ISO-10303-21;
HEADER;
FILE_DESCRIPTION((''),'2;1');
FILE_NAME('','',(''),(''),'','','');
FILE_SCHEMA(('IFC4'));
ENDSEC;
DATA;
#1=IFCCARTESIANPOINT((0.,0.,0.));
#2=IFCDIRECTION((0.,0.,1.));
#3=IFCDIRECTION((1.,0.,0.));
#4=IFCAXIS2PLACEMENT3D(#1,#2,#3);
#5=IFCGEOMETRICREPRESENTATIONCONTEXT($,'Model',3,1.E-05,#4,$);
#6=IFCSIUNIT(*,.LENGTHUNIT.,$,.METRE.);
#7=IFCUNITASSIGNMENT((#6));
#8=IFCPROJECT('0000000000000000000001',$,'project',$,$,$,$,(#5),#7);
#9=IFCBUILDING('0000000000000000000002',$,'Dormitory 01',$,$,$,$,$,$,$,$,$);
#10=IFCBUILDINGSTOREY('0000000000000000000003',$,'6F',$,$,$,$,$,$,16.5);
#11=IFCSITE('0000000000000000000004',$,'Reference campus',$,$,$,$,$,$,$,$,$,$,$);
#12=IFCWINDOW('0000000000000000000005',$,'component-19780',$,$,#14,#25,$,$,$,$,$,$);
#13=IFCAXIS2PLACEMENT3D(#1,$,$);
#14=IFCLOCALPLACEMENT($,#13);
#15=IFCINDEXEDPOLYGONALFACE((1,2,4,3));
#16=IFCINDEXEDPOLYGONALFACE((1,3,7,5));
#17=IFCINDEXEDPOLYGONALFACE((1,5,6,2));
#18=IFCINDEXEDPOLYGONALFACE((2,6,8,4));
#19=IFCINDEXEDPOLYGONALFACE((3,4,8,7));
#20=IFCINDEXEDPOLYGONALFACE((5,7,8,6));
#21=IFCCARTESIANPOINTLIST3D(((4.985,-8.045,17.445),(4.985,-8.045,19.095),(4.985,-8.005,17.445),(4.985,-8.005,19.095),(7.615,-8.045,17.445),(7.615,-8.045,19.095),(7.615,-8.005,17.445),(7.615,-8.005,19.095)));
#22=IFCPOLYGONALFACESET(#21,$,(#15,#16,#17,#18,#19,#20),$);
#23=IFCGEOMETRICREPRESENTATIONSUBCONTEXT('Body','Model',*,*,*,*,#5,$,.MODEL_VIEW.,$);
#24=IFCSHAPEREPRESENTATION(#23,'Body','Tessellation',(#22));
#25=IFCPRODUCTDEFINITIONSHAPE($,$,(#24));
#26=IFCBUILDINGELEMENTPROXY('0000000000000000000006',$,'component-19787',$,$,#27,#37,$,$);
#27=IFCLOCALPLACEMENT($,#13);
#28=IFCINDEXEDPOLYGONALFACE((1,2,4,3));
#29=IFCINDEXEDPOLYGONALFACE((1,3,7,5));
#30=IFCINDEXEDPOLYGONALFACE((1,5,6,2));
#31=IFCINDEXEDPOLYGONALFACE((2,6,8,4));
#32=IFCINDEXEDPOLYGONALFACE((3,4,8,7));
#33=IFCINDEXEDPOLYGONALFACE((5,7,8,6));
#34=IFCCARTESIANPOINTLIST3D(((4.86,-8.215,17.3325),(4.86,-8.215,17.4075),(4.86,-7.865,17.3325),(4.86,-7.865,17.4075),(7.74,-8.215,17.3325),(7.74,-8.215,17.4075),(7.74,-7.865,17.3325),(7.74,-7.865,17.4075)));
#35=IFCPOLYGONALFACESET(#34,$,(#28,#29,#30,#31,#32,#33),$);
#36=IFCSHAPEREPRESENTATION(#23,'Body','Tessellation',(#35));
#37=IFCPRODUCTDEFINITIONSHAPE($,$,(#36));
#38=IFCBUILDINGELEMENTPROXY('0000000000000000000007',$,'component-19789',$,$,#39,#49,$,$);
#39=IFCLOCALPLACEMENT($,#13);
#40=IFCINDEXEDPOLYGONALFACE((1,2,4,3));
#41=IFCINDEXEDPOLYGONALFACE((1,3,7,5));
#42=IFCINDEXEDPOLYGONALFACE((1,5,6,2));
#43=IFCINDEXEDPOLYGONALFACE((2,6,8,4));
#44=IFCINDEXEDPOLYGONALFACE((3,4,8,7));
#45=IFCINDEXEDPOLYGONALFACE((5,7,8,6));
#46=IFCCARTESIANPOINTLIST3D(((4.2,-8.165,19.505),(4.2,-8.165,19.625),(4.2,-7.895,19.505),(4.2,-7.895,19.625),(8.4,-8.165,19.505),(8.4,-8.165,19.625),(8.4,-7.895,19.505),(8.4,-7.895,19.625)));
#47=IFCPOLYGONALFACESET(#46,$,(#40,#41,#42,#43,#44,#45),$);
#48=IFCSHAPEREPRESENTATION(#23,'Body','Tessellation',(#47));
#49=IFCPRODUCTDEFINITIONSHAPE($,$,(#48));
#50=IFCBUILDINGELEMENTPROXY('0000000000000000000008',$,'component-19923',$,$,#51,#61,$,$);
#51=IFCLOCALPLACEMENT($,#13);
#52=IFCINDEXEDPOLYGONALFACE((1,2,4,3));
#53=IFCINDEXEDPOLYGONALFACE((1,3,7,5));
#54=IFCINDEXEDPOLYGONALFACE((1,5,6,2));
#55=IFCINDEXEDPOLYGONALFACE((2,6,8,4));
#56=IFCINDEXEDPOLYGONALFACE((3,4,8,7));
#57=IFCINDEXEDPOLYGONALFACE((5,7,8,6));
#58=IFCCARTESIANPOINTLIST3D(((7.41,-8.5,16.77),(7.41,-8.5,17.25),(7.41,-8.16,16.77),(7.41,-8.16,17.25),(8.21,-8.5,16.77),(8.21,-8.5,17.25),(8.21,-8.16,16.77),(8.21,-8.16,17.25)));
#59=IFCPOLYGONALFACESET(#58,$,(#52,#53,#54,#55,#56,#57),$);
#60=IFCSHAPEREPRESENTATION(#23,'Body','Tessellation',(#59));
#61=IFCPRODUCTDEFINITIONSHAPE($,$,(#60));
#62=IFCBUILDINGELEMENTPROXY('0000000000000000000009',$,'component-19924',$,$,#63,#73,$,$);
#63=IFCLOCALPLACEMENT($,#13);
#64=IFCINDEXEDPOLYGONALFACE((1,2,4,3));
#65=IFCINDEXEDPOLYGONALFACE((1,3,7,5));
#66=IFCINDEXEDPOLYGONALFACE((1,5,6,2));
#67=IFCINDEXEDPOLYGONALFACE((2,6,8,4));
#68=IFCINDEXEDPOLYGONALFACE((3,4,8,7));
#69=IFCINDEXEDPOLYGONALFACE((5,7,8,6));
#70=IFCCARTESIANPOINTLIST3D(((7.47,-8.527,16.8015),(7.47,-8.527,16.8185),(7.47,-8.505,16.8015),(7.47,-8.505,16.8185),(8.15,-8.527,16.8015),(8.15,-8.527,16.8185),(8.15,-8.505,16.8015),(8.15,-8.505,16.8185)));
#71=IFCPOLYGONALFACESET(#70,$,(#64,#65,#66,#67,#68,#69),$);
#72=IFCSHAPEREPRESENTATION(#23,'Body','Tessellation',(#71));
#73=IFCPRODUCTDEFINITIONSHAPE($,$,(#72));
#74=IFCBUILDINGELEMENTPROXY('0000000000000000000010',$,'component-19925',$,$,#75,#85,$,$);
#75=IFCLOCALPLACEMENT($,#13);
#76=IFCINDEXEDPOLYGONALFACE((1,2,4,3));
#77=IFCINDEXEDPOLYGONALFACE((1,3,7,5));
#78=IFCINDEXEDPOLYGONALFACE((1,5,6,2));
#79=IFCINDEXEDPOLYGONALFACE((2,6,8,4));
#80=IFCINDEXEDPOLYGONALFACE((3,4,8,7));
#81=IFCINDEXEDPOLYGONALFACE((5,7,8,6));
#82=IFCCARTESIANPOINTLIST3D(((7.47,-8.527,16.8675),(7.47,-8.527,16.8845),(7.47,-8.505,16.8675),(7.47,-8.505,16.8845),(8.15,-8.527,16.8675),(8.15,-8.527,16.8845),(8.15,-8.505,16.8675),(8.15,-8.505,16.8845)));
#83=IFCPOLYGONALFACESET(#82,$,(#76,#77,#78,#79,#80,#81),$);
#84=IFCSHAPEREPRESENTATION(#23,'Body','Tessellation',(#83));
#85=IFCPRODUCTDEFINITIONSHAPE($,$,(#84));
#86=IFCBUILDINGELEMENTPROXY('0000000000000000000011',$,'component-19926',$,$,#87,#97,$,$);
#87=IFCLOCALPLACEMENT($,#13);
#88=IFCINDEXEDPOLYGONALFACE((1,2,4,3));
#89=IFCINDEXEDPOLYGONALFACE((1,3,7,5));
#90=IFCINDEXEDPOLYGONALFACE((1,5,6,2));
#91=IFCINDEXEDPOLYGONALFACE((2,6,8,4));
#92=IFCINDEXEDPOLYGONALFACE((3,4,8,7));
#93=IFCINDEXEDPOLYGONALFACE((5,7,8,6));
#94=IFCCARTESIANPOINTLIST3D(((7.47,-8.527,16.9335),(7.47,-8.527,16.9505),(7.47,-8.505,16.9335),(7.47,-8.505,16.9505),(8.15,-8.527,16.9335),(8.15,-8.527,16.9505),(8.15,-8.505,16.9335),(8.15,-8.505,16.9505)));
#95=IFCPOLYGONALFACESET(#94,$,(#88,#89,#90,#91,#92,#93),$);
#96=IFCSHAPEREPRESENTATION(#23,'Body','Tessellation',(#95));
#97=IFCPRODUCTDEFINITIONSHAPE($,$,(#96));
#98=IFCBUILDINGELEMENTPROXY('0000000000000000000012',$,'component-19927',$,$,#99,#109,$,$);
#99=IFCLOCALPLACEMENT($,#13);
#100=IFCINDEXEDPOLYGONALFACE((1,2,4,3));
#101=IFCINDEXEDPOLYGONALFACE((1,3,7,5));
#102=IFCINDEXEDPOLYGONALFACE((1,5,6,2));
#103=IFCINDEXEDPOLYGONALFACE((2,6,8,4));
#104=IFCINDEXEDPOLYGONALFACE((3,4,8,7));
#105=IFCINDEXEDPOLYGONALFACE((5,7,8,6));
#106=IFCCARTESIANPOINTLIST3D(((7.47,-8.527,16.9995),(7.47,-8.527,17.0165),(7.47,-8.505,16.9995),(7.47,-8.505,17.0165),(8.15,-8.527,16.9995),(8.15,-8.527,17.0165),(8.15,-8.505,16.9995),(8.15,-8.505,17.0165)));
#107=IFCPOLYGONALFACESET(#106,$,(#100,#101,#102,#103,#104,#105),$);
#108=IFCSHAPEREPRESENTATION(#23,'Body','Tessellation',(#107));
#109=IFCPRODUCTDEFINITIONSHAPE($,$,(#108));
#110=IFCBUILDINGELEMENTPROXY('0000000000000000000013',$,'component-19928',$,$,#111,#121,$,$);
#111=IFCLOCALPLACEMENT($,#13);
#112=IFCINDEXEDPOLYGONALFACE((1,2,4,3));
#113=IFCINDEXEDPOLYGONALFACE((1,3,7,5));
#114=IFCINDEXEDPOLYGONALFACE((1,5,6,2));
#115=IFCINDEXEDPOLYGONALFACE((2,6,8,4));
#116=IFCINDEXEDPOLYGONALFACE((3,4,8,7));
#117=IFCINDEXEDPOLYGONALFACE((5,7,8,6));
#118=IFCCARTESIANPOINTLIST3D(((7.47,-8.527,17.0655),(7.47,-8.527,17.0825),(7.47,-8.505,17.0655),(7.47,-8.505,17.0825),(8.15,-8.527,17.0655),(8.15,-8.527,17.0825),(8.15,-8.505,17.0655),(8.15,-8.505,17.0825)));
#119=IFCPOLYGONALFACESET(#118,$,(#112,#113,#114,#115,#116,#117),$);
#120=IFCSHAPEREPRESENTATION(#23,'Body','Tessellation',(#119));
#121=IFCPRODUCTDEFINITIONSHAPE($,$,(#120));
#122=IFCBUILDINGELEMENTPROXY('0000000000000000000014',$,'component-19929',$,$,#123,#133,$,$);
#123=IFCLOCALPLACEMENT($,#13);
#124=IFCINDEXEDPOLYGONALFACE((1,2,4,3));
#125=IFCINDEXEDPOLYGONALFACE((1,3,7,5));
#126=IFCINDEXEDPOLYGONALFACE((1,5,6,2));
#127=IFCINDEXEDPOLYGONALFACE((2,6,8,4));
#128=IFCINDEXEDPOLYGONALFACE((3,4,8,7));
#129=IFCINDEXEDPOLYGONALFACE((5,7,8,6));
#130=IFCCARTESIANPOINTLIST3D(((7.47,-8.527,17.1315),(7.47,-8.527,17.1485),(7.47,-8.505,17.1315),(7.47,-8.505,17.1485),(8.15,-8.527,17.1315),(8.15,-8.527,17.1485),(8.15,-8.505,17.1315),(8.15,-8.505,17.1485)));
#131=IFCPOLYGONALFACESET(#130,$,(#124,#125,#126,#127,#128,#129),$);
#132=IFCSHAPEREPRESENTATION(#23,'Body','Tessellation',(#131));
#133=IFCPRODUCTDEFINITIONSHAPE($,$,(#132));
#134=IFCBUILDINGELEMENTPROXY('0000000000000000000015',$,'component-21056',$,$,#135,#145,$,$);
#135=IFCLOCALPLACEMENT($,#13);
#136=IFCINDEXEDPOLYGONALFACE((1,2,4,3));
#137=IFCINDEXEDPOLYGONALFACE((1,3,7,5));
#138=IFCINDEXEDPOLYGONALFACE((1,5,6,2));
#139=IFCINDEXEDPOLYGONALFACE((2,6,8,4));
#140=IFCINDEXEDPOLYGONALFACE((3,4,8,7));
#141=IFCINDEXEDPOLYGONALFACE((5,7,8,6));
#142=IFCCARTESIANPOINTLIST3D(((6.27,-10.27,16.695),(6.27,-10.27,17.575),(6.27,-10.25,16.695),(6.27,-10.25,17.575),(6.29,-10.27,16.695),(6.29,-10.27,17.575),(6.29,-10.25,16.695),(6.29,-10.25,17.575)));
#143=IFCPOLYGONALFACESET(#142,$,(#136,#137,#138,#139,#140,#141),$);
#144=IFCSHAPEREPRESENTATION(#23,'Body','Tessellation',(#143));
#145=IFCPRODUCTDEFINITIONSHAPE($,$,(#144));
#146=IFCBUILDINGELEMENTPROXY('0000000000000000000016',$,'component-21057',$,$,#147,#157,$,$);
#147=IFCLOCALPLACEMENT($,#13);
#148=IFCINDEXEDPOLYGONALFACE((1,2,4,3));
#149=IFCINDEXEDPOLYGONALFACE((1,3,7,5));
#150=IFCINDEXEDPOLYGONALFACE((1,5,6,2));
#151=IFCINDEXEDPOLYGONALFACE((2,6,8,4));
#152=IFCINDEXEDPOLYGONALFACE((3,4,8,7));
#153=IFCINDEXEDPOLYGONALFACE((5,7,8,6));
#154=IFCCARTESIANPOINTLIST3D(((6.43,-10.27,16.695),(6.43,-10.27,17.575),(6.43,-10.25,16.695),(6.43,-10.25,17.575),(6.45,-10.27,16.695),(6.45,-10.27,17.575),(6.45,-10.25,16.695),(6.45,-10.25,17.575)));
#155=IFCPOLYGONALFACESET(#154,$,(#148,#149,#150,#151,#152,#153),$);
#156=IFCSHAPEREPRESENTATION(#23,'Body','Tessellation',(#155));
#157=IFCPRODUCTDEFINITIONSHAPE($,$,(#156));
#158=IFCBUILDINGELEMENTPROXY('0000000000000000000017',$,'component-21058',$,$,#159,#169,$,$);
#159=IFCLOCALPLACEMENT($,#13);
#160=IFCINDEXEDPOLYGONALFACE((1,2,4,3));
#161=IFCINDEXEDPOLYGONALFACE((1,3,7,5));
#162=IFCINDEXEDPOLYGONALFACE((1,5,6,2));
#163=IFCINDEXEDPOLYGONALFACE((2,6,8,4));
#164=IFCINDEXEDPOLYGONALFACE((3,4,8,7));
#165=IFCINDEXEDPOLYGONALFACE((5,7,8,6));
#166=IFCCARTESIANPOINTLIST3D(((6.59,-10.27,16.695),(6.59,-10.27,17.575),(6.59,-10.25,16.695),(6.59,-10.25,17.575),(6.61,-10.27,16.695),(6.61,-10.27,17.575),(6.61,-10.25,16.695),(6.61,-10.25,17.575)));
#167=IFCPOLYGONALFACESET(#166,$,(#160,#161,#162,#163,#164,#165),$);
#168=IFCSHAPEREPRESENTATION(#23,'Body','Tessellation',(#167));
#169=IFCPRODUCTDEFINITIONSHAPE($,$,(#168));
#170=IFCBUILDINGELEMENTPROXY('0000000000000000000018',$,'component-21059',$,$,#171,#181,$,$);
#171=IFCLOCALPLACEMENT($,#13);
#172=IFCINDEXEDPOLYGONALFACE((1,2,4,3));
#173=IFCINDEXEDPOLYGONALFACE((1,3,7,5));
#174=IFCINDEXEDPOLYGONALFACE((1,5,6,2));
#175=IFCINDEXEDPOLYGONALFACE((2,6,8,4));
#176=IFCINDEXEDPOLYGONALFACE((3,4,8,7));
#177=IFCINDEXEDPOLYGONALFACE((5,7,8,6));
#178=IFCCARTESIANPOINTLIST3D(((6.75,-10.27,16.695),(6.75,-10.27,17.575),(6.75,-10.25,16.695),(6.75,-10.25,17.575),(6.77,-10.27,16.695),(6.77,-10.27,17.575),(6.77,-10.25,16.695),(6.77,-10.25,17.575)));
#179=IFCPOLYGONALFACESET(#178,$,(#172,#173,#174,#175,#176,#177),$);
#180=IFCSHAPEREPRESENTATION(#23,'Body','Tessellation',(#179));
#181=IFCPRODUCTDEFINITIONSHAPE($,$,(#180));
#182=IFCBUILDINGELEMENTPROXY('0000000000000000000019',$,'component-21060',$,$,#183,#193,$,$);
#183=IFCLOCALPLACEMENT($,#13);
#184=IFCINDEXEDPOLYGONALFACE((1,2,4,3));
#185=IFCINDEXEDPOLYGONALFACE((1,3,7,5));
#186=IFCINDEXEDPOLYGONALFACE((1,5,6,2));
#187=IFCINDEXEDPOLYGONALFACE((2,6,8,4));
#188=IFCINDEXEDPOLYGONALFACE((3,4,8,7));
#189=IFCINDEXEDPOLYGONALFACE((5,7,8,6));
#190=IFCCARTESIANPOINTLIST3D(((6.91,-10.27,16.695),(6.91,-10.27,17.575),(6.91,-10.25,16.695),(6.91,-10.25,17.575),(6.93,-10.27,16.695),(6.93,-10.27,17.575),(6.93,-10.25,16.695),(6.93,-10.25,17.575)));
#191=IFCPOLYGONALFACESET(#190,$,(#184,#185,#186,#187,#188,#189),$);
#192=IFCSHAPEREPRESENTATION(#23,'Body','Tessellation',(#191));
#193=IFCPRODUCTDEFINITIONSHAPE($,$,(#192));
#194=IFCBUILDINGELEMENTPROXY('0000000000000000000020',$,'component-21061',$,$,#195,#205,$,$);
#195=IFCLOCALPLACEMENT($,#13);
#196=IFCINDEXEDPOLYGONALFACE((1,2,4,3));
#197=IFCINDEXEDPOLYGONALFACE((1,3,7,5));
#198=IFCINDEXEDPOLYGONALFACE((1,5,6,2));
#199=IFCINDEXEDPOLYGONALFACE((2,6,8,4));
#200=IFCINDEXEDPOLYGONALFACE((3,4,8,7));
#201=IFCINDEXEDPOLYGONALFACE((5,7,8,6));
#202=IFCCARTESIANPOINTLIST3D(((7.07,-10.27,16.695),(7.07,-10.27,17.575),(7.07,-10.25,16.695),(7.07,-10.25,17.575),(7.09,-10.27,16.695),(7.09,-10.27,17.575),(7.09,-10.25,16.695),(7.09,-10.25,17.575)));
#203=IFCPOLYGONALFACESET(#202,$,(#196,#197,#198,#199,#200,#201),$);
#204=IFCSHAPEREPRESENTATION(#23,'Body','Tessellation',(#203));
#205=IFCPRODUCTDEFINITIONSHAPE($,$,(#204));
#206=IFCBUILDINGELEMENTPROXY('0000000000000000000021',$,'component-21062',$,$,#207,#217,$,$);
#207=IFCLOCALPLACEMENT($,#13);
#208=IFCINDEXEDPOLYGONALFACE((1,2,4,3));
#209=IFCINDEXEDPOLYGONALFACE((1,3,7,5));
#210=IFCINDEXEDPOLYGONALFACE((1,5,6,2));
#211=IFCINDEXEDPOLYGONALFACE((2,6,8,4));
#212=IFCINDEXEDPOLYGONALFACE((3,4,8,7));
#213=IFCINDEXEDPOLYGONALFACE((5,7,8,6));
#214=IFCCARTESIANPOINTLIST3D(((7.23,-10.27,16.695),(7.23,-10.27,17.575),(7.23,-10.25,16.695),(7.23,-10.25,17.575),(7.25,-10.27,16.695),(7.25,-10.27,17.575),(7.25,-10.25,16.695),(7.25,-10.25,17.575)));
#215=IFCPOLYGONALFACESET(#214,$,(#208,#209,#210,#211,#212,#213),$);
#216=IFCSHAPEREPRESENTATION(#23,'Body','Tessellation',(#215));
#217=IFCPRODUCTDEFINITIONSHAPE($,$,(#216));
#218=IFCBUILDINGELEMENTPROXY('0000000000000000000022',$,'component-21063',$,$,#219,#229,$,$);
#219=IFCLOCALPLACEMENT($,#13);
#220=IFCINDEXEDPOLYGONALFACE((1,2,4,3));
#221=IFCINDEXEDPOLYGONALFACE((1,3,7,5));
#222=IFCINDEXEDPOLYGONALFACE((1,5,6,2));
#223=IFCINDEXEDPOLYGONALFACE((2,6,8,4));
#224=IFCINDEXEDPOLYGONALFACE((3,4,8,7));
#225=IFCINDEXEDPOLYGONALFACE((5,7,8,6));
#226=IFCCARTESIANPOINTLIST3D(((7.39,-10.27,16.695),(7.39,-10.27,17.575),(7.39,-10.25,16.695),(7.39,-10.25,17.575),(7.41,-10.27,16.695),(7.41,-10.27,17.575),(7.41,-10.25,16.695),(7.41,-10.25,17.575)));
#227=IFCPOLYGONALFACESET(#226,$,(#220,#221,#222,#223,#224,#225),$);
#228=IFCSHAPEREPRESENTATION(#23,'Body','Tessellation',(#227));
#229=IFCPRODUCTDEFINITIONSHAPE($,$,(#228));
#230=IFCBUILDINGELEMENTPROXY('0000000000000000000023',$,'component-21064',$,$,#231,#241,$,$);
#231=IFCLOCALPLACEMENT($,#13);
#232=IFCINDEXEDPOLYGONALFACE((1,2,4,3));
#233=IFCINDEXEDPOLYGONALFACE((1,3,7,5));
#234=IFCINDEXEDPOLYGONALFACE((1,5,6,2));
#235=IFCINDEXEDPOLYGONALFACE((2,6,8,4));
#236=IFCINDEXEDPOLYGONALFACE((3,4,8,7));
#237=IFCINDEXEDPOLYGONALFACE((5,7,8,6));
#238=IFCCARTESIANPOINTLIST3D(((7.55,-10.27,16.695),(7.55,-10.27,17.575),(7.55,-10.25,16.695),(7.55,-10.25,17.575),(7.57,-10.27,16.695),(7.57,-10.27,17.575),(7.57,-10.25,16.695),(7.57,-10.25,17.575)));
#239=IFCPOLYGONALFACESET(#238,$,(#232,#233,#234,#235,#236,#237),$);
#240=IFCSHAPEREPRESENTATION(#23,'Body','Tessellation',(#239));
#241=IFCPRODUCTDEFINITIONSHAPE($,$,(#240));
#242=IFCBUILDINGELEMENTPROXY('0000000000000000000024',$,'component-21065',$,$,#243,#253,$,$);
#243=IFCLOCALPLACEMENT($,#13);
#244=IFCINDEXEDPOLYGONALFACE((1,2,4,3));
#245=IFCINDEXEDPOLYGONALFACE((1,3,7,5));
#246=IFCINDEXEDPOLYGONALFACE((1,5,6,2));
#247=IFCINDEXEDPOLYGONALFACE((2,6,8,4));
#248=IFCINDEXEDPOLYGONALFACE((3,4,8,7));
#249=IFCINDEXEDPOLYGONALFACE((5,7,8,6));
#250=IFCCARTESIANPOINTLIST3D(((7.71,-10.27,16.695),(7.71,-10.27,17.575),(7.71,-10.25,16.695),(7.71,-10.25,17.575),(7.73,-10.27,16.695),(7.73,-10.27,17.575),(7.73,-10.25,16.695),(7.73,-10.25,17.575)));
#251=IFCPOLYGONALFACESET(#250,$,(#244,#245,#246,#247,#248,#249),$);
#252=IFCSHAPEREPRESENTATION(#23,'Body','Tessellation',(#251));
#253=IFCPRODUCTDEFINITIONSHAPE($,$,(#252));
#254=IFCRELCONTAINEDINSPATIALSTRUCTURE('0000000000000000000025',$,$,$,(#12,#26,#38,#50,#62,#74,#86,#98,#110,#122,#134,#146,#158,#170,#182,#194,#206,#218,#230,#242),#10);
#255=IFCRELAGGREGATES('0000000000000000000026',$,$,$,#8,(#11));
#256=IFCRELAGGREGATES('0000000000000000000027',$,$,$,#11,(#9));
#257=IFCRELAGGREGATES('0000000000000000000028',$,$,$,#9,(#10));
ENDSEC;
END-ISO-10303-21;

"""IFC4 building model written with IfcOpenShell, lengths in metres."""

from ifc_helpers import new_model, si_unit, frame, origin, origin_with_axes, origin_2d, place, context, subcontext, project, spatial, rectangle, extrude, element, save


model = new_model("IFC4")

# Units and contexts
model_context = context("Model", 3, precision=1e-05, world=origin_with_axes())
body_context = subcontext(model_context, "Body", "Model", "MODEL_VIEW")
ifc_project = project(units=[si_unit("LENGTHUNIT", "METRE")], contexts=[model_context])

# Site, building, storey
site = spatial("IfcSite", under=ifc_project, Name="Reference campus")
building = spatial("IfcBuilding", under=site, Name="Dormitory 01")
storey = spatial("IfcBuildingStorey", under=building, Name="6F", Elevation=16.5)

# Window
window_placement = place(None, frame((6.3, -8.025, 17.445), z_axis=(0.0, 0.0, 1.0), x_axis=(1.0, 0.0, 0.0)))
element("IfcWindow", 1, at=window_placement, inside=storey, Name="component-19780", context=body_context, shape_type="SweptSolid", body=[
    extrude(rectangle(XDim=2.63, YDim=0.04, at=origin_2d()), origin(), (0.0, 0.0, 1.0), 1.65),
])

# Building element proxies
proxy_1_placement = place(None, frame((6.3, -8.04, 17.3325), z_axis=(0.0, 0.0, 1.0), x_axis=(1.0, 0.0, 0.0)))
element("IfcBuildingElementProxy", 2, at=proxy_1_placement, inside=storey, Name="component-19787", context=body_context, shape_type="SweptSolid", body=[
    extrude(rectangle(XDim=2.88, YDim=0.35, at=origin_2d()), origin(), (0.0, 0.0, 1.0), 0.075),
])
proxy_2_placement = place(None, frame((6.3, -8.03, 19.505), z_axis=(0.0, 0.0, 1.0), x_axis=(1.0, 0.0, 0.0)))
element("IfcBuildingElementProxy", 3, at=proxy_2_placement, inside=storey, Name="component-19789", context=body_context, shape_type="SweptSolid", body=[
    extrude(rectangle(XDim=4.2, YDim=0.27, at=origin_2d()), origin(), (0.0, 0.0, 1.0), 0.12),
])
proxy_3_placement = place(None, frame((7.81, -8.33, 16.77), z_axis=(0.0, 0.0, 1.0), x_axis=(1.0, 0.0, 0.0)))
element("IfcBuildingElementProxy", 4, at=proxy_3_placement, inside=storey, Name="component-19923", context=body_context, shape_type="SweptSolid", body=[
    extrude(rectangle(XDim=0.8, YDim=0.34, at=origin_2d()), origin(), (0.0, 0.0, 1.0), 0.48),
])
for number, where, z_axis, x_axis, name in (
    (5, (7.81, -8.516, 16.8015), (0.0, 0.0, 1.0), (1.0, 0.0, 0.0), "component-19924"),
    (6, (7.81, -8.516, 16.8675), (0.0, 0.0, 1.0), (1.0, 0.0, 0.0), "component-19925"),
    (7, (7.81, -8.516, 16.9335), (0.0, 0.0, 1.0), (1.0, 0.0, 0.0), "component-19926"),
    (8, (7.81, -8.516, 16.9995), (0.0, 0.0, 1.0), (1.0, 0.0, 0.0), "component-19927"),
    (9, (7.81, -8.516, 17.0655), (0.0, 0.0, 1.0), (1.0, 0.0, 0.0), "component-19928"),
    (10, (7.81, -8.516, 17.1315), (0.0, 0.0, 1.0), (1.0, 0.0, 0.0), "component-19929"),
):
    element("IfcBuildingElementProxy", number, at=place(None, frame(where, z_axis=z_axis, x_axis=x_axis)), inside=storey, Name=name, context=body_context, shape_type="SweptSolid", body=[
        extrude(rectangle(XDim=0.68, YDim=0.022, at=origin_2d()), origin(), (0.0, 0.0, 1.0), 0.017),
    ])
for number, where, z_axis, x_axis, name in (
    (11, (6.28, -10.26, 16.695), (0.0, 0.0, 1.0), (1.0, 0.0, 0.0), "component-21056"),
    (12, (6.44, -10.26, 16.695), (0.0, 0.0, 1.0), (1.0, 0.0, 0.0), "component-21057"),
    (13, (6.6, -10.26, 16.695), (0.0, 0.0, 1.0), (1.0, 0.0, 0.0), "component-21058"),
    (14, (6.76, -10.26, 16.695), (0.0, 0.0, 1.0), (1.0, 0.0, 0.0), "component-21059"),
    (15, (6.92, -10.26, 16.695), (0.0, 0.0, 1.0), (1.0, 0.0, 0.0), "component-21060"),
    (16, (7.08, -10.26, 16.695), (0.0, 0.0, 1.0), (1.0, 0.0, 0.0), "component-21061"),
    (17, (7.24, -10.26, 16.695), (0.0, 0.0, 1.0), (1.0, 0.0, 0.0), "component-21062"),
    (18, (7.4, -10.26, 16.695), (0.0, 0.0, 1.0), (1.0, 0.0, 0.0), "component-21063"),
    (19, (7.56, -10.26, 16.695), (0.0, 0.0, 1.0), (1.0, 0.0, 0.0), "component-21064"),
    (20, (7.72, -10.26, 16.695), (0.0, 0.0, 1.0), (1.0, 0.0, 0.0), "component-21065"),
):
    element("IfcBuildingElementProxy", number, at=place(None, frame(where, z_axis=z_axis, x_axis=x_axis)), inside=storey, Name=name, context=body_context, shape_type="SweptSolid", body=[
        extrude(rectangle(XDim=0.02, YDim=0.02, at=origin_2d()), origin(), (0.0, 0.0, 1.0), 0.88),
    ])

save(model, "model.ifc")
